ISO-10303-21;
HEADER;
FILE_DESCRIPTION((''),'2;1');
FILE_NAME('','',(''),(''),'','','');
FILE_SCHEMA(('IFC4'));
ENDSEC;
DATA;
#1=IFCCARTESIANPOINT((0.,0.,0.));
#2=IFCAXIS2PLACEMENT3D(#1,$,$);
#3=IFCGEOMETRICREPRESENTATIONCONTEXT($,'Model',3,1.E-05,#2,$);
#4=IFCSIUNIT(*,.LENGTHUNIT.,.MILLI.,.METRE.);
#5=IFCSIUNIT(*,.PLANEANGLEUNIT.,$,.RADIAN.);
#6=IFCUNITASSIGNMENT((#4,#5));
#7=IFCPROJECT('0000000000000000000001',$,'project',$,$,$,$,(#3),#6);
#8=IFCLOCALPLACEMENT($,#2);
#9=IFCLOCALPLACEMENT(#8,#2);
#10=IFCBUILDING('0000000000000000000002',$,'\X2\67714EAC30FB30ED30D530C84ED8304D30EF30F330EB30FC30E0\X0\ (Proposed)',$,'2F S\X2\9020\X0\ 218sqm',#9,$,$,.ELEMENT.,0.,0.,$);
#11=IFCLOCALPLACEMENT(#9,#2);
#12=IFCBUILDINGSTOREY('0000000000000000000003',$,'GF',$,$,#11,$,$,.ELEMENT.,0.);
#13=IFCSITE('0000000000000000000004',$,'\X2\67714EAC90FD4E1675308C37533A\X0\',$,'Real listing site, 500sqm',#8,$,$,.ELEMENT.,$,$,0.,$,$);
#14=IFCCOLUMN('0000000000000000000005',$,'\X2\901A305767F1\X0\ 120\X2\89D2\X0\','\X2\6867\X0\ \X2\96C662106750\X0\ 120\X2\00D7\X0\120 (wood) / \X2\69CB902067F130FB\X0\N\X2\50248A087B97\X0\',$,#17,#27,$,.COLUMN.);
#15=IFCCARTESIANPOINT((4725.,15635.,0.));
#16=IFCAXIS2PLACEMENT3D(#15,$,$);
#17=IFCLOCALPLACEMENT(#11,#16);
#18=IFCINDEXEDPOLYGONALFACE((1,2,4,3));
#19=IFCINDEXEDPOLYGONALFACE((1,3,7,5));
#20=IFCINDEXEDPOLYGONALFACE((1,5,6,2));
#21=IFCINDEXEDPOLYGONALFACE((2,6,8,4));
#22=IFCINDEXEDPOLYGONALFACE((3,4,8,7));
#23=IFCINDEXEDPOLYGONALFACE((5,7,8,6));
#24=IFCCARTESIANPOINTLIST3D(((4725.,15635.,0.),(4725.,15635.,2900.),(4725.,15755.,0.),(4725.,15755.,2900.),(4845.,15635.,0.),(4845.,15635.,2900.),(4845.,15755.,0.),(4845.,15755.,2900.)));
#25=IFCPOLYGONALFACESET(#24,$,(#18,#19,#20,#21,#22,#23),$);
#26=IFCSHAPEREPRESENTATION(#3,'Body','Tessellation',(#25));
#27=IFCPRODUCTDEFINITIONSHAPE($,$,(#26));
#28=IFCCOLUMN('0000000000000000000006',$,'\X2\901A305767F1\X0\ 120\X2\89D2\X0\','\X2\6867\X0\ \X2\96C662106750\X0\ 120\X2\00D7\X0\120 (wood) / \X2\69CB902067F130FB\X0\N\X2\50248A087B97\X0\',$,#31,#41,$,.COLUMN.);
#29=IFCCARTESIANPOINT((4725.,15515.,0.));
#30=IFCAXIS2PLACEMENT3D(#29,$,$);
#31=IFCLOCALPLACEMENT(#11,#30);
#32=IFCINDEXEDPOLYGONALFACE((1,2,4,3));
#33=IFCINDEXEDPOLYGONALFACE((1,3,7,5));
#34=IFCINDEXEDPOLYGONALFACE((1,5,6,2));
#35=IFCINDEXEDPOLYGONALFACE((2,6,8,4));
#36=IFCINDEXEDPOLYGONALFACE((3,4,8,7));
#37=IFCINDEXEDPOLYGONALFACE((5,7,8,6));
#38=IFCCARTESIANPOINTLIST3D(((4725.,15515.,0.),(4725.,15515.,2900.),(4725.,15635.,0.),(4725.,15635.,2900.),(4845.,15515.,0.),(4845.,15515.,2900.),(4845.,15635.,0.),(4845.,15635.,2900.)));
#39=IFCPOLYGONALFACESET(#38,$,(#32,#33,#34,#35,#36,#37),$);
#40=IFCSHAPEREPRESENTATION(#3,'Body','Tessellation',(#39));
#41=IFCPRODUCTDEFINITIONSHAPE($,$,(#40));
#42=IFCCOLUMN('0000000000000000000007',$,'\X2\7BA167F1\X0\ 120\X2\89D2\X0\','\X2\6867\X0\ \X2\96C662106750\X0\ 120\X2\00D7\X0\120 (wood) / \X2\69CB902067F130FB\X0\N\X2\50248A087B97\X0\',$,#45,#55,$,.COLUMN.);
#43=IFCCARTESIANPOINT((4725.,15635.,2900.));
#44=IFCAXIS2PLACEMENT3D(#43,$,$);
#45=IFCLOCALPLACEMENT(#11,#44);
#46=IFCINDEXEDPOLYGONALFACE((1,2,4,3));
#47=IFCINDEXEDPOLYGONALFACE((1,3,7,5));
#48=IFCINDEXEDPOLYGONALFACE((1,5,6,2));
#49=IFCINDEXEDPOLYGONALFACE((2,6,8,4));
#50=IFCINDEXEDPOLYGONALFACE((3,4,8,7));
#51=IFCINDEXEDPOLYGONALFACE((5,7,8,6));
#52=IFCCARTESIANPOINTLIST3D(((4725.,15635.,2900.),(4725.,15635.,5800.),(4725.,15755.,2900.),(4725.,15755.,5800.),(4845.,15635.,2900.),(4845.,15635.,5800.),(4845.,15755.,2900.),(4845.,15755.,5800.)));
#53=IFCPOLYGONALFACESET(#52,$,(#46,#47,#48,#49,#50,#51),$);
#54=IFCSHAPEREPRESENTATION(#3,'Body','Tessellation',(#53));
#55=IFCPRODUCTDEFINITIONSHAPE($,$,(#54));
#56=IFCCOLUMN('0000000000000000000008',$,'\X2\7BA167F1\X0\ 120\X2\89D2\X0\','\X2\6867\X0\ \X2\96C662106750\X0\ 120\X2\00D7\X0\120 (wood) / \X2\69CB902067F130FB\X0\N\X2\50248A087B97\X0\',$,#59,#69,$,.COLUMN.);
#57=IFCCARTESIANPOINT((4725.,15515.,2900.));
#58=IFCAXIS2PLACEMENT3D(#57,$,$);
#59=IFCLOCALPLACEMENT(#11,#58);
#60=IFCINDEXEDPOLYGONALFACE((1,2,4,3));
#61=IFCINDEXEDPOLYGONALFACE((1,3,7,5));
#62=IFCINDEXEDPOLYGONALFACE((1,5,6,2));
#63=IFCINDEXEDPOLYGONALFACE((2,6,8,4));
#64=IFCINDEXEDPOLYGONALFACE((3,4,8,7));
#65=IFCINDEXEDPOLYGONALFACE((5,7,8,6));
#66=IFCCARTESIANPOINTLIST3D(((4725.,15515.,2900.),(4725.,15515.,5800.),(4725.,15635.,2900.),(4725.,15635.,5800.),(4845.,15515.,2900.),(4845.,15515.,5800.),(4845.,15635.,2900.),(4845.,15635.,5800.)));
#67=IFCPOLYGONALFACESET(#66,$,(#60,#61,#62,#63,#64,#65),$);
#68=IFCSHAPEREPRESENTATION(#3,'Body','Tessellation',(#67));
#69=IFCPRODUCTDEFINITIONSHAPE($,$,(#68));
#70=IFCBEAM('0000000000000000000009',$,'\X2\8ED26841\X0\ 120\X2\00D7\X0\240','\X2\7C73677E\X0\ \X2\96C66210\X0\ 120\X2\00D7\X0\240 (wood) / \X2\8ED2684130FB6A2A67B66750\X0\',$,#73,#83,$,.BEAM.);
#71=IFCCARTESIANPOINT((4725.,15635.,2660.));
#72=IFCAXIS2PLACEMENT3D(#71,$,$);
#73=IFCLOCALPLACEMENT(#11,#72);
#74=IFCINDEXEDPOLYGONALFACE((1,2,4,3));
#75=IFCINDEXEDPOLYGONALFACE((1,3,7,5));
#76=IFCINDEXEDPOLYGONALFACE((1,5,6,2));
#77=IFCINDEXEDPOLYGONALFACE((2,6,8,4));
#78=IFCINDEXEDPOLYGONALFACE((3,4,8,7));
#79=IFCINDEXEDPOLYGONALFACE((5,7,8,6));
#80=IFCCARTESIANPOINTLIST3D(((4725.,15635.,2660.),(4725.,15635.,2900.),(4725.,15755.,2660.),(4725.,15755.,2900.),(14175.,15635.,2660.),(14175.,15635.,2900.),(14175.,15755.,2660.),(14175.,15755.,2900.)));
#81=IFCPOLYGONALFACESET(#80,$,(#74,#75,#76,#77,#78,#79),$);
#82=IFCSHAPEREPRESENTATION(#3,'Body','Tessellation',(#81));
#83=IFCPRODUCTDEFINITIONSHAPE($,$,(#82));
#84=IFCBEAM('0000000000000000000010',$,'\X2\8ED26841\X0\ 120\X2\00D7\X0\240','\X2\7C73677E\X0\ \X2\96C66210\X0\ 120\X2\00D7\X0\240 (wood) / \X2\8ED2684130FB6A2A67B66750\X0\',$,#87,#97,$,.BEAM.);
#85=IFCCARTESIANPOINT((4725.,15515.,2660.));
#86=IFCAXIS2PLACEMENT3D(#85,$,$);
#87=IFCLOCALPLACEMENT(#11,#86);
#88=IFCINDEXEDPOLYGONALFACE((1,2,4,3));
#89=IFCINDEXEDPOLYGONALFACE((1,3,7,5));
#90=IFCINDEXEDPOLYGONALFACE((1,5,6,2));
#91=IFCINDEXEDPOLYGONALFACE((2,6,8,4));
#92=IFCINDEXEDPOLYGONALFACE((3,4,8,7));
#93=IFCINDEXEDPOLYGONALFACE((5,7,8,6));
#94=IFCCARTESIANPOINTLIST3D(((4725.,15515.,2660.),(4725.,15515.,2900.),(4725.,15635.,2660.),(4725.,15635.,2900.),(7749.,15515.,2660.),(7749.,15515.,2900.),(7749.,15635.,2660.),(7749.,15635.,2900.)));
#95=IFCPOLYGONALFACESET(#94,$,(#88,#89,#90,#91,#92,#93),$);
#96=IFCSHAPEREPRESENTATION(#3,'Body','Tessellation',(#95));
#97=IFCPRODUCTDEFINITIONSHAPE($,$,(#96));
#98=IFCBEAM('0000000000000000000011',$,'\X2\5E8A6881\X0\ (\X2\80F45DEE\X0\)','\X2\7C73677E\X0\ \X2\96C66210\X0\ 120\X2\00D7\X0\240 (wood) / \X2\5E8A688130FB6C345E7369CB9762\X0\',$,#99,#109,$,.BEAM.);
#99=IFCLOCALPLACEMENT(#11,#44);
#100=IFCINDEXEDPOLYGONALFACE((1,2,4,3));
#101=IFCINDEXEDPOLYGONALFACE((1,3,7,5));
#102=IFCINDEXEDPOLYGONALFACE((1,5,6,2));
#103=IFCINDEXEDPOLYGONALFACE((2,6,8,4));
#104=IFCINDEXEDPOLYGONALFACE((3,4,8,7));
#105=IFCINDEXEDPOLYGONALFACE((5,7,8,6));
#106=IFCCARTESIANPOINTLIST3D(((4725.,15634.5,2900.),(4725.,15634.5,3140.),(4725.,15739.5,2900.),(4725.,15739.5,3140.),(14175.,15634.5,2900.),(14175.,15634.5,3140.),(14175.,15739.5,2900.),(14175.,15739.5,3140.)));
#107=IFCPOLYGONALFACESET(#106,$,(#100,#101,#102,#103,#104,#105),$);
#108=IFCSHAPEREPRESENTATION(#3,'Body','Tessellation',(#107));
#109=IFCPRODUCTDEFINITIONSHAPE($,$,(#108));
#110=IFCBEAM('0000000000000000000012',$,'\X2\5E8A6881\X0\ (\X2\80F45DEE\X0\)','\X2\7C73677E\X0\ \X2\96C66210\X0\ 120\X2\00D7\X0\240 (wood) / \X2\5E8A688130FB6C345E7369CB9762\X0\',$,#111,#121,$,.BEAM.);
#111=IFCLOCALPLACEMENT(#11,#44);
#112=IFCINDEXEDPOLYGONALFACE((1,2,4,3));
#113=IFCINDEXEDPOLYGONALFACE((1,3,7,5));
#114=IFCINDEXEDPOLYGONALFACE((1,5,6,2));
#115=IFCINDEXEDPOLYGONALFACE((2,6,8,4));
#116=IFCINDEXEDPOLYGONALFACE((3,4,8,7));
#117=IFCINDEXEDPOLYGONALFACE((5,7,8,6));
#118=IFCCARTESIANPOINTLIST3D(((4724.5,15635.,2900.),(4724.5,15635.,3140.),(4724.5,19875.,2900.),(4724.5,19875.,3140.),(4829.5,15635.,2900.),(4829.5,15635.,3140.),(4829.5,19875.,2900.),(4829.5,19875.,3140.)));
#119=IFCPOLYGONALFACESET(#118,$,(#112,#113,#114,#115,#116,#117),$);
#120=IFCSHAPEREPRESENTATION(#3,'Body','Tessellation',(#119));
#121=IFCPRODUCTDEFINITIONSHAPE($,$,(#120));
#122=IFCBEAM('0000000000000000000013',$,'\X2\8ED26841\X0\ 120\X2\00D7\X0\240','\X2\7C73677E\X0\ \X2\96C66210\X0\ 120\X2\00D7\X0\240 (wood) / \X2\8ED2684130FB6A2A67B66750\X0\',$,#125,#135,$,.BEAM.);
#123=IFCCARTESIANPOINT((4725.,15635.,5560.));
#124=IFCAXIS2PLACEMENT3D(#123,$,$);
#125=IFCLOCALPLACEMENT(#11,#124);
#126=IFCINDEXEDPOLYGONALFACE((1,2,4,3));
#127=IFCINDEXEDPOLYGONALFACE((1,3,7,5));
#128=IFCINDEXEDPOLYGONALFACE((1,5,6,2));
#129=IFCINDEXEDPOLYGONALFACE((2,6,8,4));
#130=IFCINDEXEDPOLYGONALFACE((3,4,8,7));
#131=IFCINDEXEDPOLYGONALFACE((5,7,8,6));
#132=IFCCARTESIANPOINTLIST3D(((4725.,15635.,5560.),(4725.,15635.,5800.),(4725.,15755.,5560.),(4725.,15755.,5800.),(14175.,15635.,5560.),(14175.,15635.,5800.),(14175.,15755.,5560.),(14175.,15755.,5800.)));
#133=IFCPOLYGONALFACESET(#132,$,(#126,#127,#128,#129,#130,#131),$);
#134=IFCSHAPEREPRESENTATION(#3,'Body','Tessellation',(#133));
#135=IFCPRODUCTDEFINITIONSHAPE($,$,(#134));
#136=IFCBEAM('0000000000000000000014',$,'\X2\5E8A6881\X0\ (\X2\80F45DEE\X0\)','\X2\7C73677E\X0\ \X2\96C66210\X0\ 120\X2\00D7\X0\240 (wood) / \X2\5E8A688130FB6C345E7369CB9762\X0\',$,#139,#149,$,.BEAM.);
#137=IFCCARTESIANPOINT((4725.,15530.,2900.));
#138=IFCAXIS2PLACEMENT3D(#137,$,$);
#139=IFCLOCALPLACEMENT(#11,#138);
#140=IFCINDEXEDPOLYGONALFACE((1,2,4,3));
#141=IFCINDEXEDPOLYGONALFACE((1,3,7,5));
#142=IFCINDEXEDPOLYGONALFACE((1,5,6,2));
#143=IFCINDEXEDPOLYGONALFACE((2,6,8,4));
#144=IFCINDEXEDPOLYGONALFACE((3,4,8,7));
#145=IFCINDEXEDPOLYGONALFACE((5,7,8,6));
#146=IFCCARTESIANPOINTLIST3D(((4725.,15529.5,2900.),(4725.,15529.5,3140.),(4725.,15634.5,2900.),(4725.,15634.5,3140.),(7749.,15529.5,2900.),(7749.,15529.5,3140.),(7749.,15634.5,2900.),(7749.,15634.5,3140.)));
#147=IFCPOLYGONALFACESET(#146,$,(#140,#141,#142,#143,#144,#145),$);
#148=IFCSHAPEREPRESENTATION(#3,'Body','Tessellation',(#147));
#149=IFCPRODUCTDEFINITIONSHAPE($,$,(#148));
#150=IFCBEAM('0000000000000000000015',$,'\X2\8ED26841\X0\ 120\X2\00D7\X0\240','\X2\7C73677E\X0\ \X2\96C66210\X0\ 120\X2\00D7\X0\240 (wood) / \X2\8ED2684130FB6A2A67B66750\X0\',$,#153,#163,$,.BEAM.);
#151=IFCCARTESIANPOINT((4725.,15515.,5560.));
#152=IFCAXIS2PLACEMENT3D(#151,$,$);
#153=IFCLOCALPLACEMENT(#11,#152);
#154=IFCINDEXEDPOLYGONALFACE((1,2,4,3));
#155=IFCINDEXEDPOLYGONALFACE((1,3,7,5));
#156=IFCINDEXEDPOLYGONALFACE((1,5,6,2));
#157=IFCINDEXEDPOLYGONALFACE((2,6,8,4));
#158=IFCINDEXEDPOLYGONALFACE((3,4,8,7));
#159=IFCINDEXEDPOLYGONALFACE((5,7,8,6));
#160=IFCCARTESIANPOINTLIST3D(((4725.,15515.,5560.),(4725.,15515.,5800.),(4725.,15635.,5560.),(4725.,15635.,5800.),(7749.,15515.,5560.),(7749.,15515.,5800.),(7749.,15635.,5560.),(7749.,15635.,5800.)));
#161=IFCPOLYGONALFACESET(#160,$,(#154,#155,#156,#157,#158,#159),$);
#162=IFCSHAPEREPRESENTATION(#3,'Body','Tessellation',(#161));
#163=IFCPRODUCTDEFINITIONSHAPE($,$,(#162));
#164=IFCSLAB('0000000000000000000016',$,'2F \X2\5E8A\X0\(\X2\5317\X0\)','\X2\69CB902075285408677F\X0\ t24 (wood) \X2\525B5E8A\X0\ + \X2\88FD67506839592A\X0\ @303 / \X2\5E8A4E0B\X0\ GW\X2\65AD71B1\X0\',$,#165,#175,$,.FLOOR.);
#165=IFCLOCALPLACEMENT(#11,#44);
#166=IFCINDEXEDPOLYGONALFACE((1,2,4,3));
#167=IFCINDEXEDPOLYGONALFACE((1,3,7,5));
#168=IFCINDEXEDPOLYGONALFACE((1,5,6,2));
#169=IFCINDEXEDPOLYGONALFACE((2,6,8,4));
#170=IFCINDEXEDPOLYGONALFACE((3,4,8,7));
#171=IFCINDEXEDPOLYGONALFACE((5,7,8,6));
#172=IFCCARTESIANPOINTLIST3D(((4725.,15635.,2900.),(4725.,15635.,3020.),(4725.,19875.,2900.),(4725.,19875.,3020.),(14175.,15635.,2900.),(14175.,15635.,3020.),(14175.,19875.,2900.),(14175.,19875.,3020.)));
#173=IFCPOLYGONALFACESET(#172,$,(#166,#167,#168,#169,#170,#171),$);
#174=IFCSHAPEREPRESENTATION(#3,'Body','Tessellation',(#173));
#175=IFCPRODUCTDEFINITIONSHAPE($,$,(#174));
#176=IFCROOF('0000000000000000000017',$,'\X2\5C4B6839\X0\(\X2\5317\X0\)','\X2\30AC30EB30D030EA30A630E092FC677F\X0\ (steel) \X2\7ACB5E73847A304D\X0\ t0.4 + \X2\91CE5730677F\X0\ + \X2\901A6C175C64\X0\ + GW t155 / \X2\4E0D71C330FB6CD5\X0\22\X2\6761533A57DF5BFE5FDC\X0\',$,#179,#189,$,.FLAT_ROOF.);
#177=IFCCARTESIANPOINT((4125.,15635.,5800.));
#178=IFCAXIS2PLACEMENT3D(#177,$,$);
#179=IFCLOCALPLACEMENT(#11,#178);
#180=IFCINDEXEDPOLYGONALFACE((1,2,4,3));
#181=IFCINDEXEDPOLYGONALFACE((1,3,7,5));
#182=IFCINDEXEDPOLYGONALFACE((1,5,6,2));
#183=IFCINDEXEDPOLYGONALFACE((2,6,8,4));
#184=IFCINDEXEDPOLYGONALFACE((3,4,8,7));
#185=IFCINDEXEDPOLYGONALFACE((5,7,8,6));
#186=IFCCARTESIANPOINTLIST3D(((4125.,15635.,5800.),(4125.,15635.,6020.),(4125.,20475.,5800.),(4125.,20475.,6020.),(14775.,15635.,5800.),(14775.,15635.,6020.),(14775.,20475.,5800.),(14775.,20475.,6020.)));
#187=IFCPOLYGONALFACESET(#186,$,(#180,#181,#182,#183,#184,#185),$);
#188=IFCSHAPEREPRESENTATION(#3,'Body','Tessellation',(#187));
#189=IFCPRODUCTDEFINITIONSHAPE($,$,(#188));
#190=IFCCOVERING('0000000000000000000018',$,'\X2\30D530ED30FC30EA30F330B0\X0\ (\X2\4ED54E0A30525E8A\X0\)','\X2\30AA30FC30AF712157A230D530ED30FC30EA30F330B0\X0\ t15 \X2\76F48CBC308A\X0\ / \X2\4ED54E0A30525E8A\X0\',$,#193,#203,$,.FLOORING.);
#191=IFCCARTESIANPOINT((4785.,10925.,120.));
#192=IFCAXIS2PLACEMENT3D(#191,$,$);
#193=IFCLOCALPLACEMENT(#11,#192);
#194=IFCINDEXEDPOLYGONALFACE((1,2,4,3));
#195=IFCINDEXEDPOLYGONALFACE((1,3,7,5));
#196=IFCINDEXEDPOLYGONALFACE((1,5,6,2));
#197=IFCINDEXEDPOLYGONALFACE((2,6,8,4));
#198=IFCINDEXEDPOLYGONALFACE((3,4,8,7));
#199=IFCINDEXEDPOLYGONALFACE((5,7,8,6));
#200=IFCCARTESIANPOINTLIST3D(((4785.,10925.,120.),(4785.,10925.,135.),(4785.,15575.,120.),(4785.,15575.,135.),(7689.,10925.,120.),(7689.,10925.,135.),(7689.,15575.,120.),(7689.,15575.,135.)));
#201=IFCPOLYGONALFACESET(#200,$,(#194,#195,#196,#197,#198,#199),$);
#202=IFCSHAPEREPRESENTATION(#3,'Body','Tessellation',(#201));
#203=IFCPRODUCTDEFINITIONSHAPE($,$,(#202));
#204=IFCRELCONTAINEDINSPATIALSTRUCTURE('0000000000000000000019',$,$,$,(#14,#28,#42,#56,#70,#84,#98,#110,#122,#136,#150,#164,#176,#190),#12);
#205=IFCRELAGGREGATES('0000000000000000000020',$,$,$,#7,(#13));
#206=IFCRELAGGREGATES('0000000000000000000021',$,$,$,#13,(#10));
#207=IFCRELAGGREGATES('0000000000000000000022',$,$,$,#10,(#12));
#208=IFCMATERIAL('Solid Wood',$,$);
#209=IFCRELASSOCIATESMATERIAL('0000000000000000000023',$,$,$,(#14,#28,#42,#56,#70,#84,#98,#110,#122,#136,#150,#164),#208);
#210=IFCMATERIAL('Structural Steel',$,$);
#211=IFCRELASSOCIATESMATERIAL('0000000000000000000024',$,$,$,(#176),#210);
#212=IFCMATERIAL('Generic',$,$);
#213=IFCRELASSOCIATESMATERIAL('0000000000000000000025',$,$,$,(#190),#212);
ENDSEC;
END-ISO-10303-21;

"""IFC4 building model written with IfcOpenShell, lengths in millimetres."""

from ifc_helpers import new_model, si_unit, frame, frame_2d, origin, place, context, project, spatial, rectangle, extrude, material, element, save


model = new_model("IFC4")

# Units and contexts
model_context = context("Model", 3, precision=1e-05, world=origin())
ifc_project = project(units=[si_unit("LENGTHUNIT", "METRE", prefix="MILLI"), si_unit("PLANEANGLEUNIT", "RADIAN")], contexts=[model_context])

# Site, building, storey
site_placement = place(None, origin())
site = spatial("IfcSite", under=ifc_project, at=site_placement, Name="東京都世田谷区", ObjectType="Real listing site, 500sqm", CompositionType="ELEMENT", RefElevation=0.0)
building_placement = place(site_placement, origin())
building = spatial("IfcBuilding", under=site, at=building_placement, Name="東京・ロフト付きワンルーム (Proposed)", ObjectType="2F S造 218sqm", CompositionType="ELEMENT", ElevationOfRefHeight=0.0, ElevationOfTerrain=0.0)
storey_placement = place(building_placement, origin())
storey = spatial("IfcBuildingStorey", under=building, at=storey_placement, Name="GF", CompositionType="ELEMENT", Elevation=0.0)

# Columns
ifc_material_1 = material(Name="Solid Wood")
column_1_placement = place(storey_placement, frame((4725.0, 15635.0, 0.0)))
element("IfcColumn", 1, at=column_1_placement, inside=storey, material=ifc_material_1, Name="通し柱 120角", Description="桧 集成材 120×120 (wood) / 構造柱・N値計算", PredefinedType="COLUMN", context=model_context, shape_type="SweptSolid", body=[
    extrude(rectangle(XDim=120.0, YDim=120.0, at=frame_2d((60.0, 60.0))), frame((4725.0, 15635.0, 0.0)), (0.0, 0.0, 1.0), 2900.0),
])
column_2_placement = place(storey_placement, frame((4725.0, 15515.0, 0.0)))
element("IfcColumn", 2, at=column_2_placement, inside=storey, material=ifc_material_1, Name="通し柱 120角", Description="桧 集成材 120×120 (wood) / 構造柱・N値計算", PredefinedType="COLUMN", context=model_context, shape_type="SweptSolid", body=[
    extrude(rectangle(XDim=120.0, YDim=120.0, at=frame_2d((60.0, 60.0))), frame((4725.0, 15515.0, 0.0)), (0.0, 0.0, 1.0), 2900.0),
])
column_3_placement = place(storey_placement, frame((4725.0, 15635.0, 2900.0)))
element("IfcColumn", 3, at=column_3_placement, inside=storey, material=ifc_material_1, Name="管柱 120角", Description="桧 集成材 120×120 (wood) / 構造柱・N値計算", PredefinedType="COLUMN", context=model_context, shape_type="SweptSolid", body=[
    extrude(rectangle(XDim=120.0, YDim=120.0, at=frame_2d((60.0, 60.0))), frame((4725.0, 15635.0, 2900.0)), (0.0, 0.0, 1.0), 2900.0),
])
column_4_placement = place(storey_placement, frame((4725.0, 15515.0, 2900.0)))
element("IfcColumn", 4, at=column_4_placement, inside=storey, material=ifc_material_1, Name="管柱 120角", Description="桧 集成材 120×120 (wood) / 構造柱・N値計算", PredefinedType="COLUMN", context=model_context, shape_type="SweptSolid", body=[
    extrude(rectangle(XDim=120.0, YDim=120.0, at=frame_2d((60.0, 60.0))), frame((4725.0, 15515.0, 2900.0)), (0.0, 0.0, 1.0), 2900.0),
])

# Beams
beam_1_placement = place(storey_placement, frame((4725.0, 15635.0, 2660.0)))
element("IfcBeam", 5, at=beam_1_placement, inside=storey, material=ifc_material_1, Name="軒桁 120×240", Description="米松 集成 120×240 (wood) / 軒桁・横架材", PredefinedType="BEAM", context=model_context, shape_type="SweptSolid", body=[
    extrude(rectangle(XDim=9450.0, YDim=120.0, at=frame_2d((4725.0, 60.0))), frame((4725.0, 15635.0, 2660.0)), (0.0, 0.0, 1.0), 240.0),
])
beam_2_placement = place(storey_placement, frame((4725.0, 15515.0, 2660.0)))
element("IfcBeam", 6, at=beam_2_placement, inside=storey, material=ifc_material_1, Name="軒桁 120×240", Description="米松 集成 120×240 (wood) / 軒桁・横架材", PredefinedType="BEAM", context=model_context, shape_type="SweptSolid", body=[
    extrude(rectangle(XDim=3024.0, YDim=120.0, at=frame_2d((1512.0, 60.0))), frame((4725.0, 15515.0, 2660.0)), (0.0, 0.0, 1.0), 240.0),
])
beam_3_placement = place(storey_placement, frame((4725.0, 15635.0, 2900.0)))
element("IfcBeam", 7, at=beam_3_placement, inside=storey, material=ifc_material_1, Name="床梁 (胴差)", Description="米松 集成 120×240 (wood) / 床梁・水平構面", PredefinedType="BEAM", context=model_context, shape_type="SweptSolid", body=[
    extrude(rectangle(XDim=9450.0, YDim=105.0, at=frame_2d((4725.0, 52.0))), frame((4725.0, 15635.0, 2900.0)), (0.0, 0.0, 1.0), 240.0),
])
beam_4_placement = place(storey_placement, frame((4725.0, 15635.0, 2900.0)))
element("IfcBeam", 8, at=beam_4_placement, inside=storey, material=ifc_material_1, Name="床梁 (胴差)", Description="米松 集成 120×240 (wood) / 床梁・水平構面", PredefinedType="BEAM", context=model_context, shape_type="SweptSolid", body=[
    extrude(rectangle(XDim=105.0, YDim=4240.0, at=frame_2d((52.0, 2120.0))), frame((4725.0, 15635.0, 2900.0)), (0.0, 0.0, 1.0), 240.0),
])
beam_5_placement = place(storey_placement, frame((4725.0, 15635.0, 5560.0)))
element("IfcBeam", 9, at=beam_5_placement, inside=storey, material=ifc_material_1, Name="軒桁 120×240", Description="米松 集成 120×240 (wood) / 軒桁・横架材", PredefinedType="BEAM", context=model_context, shape_type="SweptSolid", body=[
    extrude(rectangle(XDim=9450.0, YDim=120.0, at=frame_2d((4725.0, 60.0))), frame((4725.0, 15635.0, 5560.0)), (0.0, 0.0, 1.0), 240.0),
])
beam_6_placement = place(storey_placement, frame((4725.0, 15530.0, 2900.0)))
element("IfcBeam", 10, at=beam_6_placement, inside=storey, material=ifc_material_1, Name="床梁 (胴差)", Description="米松 集成 120×240 (wood) / 床梁・水平構面", PredefinedType="BEAM", context=model_context, shape_type="SweptSolid", body=[
    extrude(rectangle(XDim=3024.0, YDim=105.0, at=frame_2d((1512.0, 52.0))), frame((4725.0, 15530.0, 2900.0)), (0.0, 0.0, 1.0), 240.0),
])
beam_7_placement = place(storey_placement, frame((4725.0, 15515.0, 5560.0)))
element("IfcBeam", 11, at=beam_7_placement, inside=storey, material=ifc_material_1, Name="軒桁 120×240", Description="米松 集成 120×240 (wood) / 軒桁・横架材", PredefinedType="BEAM", context=model_context, shape_type="SweptSolid", body=[
    extrude(rectangle(XDim=3024.0, YDim=120.0, at=frame_2d((1512.0, 60.0))), frame((4725.0, 15515.0, 5560.0)), (0.0, 0.0, 1.0), 240.0),
])

# Slab
slab_1_placement = place(storey_placement, frame((4725.0, 15635.0, 2900.0)))
element("IfcSlab", 12, at=slab_1_placement, inside=storey, material=ifc_material_1, Name="2F 床(北)", Description="構造用合板 t24 (wood) 剛床 + 製材根太 @303 / 床下 GW断熱", PredefinedType="FLOOR", context=model_context, shape_type="SweptSolid", body=[
    extrude(rectangle(XDim=9450.0, YDim=4240.0, at=frame_2d((4725.0, 2120.0))), frame((4725.0, 15635.0, 2900.0)), (0.0, 0.0, 1.0), 120.0),
])

# Roof
ifc_material_2 = material(Name="Structural Steel")
for number, where, name in (
    (13, (4125.0, 15635.0, 5800.0), "屋根(北)"),
):
    element("IfcRoof", number, at=place(storey_placement, frame(where)), inside=storey, material=ifc_material_2, Name=name, Description="ガルバリウム鋼板 (steel) 立平葺き t0.4 + 野地板 + 通気層 + GW t155 / 不燃・法22条区域対応", PredefinedType="FLAT_ROOF", context=model_context, shape_type="SweptSolid", body=[
        extrude(rectangle(XDim=10650.0, YDim=4840.0, at=frame_2d((5325.0, 2420.0))), frame((4125.0, 15635.0, 5800.0)), (0.0, 0.0, 1.0), 220.0),
    ])

# Covering
ifc_material_3 = material(Name="Generic")
covering_1_placement = place(storey_placement, frame((4785.0, 10925.0, 120.0)))
element("IfcCovering", 14, at=covering_1_placement, inside=storey, material=ifc_material_3, Name="フローリング (仕上げ床)", Description="オーク無垢フローリング t15 直貼り / 仕上げ床", PredefinedType="FLOORING", context=model_context, shape_type="SweptSolid", body=[
    extrude(rectangle(XDim=2904.0, YDim=4650.0, at=frame_2d((1452.0, 2325.0))), frame((4785.0, 10925.0, 120.0)), (0.0, 0.0, 1.0), 15.0),
])

save(model, "model.ifc")
